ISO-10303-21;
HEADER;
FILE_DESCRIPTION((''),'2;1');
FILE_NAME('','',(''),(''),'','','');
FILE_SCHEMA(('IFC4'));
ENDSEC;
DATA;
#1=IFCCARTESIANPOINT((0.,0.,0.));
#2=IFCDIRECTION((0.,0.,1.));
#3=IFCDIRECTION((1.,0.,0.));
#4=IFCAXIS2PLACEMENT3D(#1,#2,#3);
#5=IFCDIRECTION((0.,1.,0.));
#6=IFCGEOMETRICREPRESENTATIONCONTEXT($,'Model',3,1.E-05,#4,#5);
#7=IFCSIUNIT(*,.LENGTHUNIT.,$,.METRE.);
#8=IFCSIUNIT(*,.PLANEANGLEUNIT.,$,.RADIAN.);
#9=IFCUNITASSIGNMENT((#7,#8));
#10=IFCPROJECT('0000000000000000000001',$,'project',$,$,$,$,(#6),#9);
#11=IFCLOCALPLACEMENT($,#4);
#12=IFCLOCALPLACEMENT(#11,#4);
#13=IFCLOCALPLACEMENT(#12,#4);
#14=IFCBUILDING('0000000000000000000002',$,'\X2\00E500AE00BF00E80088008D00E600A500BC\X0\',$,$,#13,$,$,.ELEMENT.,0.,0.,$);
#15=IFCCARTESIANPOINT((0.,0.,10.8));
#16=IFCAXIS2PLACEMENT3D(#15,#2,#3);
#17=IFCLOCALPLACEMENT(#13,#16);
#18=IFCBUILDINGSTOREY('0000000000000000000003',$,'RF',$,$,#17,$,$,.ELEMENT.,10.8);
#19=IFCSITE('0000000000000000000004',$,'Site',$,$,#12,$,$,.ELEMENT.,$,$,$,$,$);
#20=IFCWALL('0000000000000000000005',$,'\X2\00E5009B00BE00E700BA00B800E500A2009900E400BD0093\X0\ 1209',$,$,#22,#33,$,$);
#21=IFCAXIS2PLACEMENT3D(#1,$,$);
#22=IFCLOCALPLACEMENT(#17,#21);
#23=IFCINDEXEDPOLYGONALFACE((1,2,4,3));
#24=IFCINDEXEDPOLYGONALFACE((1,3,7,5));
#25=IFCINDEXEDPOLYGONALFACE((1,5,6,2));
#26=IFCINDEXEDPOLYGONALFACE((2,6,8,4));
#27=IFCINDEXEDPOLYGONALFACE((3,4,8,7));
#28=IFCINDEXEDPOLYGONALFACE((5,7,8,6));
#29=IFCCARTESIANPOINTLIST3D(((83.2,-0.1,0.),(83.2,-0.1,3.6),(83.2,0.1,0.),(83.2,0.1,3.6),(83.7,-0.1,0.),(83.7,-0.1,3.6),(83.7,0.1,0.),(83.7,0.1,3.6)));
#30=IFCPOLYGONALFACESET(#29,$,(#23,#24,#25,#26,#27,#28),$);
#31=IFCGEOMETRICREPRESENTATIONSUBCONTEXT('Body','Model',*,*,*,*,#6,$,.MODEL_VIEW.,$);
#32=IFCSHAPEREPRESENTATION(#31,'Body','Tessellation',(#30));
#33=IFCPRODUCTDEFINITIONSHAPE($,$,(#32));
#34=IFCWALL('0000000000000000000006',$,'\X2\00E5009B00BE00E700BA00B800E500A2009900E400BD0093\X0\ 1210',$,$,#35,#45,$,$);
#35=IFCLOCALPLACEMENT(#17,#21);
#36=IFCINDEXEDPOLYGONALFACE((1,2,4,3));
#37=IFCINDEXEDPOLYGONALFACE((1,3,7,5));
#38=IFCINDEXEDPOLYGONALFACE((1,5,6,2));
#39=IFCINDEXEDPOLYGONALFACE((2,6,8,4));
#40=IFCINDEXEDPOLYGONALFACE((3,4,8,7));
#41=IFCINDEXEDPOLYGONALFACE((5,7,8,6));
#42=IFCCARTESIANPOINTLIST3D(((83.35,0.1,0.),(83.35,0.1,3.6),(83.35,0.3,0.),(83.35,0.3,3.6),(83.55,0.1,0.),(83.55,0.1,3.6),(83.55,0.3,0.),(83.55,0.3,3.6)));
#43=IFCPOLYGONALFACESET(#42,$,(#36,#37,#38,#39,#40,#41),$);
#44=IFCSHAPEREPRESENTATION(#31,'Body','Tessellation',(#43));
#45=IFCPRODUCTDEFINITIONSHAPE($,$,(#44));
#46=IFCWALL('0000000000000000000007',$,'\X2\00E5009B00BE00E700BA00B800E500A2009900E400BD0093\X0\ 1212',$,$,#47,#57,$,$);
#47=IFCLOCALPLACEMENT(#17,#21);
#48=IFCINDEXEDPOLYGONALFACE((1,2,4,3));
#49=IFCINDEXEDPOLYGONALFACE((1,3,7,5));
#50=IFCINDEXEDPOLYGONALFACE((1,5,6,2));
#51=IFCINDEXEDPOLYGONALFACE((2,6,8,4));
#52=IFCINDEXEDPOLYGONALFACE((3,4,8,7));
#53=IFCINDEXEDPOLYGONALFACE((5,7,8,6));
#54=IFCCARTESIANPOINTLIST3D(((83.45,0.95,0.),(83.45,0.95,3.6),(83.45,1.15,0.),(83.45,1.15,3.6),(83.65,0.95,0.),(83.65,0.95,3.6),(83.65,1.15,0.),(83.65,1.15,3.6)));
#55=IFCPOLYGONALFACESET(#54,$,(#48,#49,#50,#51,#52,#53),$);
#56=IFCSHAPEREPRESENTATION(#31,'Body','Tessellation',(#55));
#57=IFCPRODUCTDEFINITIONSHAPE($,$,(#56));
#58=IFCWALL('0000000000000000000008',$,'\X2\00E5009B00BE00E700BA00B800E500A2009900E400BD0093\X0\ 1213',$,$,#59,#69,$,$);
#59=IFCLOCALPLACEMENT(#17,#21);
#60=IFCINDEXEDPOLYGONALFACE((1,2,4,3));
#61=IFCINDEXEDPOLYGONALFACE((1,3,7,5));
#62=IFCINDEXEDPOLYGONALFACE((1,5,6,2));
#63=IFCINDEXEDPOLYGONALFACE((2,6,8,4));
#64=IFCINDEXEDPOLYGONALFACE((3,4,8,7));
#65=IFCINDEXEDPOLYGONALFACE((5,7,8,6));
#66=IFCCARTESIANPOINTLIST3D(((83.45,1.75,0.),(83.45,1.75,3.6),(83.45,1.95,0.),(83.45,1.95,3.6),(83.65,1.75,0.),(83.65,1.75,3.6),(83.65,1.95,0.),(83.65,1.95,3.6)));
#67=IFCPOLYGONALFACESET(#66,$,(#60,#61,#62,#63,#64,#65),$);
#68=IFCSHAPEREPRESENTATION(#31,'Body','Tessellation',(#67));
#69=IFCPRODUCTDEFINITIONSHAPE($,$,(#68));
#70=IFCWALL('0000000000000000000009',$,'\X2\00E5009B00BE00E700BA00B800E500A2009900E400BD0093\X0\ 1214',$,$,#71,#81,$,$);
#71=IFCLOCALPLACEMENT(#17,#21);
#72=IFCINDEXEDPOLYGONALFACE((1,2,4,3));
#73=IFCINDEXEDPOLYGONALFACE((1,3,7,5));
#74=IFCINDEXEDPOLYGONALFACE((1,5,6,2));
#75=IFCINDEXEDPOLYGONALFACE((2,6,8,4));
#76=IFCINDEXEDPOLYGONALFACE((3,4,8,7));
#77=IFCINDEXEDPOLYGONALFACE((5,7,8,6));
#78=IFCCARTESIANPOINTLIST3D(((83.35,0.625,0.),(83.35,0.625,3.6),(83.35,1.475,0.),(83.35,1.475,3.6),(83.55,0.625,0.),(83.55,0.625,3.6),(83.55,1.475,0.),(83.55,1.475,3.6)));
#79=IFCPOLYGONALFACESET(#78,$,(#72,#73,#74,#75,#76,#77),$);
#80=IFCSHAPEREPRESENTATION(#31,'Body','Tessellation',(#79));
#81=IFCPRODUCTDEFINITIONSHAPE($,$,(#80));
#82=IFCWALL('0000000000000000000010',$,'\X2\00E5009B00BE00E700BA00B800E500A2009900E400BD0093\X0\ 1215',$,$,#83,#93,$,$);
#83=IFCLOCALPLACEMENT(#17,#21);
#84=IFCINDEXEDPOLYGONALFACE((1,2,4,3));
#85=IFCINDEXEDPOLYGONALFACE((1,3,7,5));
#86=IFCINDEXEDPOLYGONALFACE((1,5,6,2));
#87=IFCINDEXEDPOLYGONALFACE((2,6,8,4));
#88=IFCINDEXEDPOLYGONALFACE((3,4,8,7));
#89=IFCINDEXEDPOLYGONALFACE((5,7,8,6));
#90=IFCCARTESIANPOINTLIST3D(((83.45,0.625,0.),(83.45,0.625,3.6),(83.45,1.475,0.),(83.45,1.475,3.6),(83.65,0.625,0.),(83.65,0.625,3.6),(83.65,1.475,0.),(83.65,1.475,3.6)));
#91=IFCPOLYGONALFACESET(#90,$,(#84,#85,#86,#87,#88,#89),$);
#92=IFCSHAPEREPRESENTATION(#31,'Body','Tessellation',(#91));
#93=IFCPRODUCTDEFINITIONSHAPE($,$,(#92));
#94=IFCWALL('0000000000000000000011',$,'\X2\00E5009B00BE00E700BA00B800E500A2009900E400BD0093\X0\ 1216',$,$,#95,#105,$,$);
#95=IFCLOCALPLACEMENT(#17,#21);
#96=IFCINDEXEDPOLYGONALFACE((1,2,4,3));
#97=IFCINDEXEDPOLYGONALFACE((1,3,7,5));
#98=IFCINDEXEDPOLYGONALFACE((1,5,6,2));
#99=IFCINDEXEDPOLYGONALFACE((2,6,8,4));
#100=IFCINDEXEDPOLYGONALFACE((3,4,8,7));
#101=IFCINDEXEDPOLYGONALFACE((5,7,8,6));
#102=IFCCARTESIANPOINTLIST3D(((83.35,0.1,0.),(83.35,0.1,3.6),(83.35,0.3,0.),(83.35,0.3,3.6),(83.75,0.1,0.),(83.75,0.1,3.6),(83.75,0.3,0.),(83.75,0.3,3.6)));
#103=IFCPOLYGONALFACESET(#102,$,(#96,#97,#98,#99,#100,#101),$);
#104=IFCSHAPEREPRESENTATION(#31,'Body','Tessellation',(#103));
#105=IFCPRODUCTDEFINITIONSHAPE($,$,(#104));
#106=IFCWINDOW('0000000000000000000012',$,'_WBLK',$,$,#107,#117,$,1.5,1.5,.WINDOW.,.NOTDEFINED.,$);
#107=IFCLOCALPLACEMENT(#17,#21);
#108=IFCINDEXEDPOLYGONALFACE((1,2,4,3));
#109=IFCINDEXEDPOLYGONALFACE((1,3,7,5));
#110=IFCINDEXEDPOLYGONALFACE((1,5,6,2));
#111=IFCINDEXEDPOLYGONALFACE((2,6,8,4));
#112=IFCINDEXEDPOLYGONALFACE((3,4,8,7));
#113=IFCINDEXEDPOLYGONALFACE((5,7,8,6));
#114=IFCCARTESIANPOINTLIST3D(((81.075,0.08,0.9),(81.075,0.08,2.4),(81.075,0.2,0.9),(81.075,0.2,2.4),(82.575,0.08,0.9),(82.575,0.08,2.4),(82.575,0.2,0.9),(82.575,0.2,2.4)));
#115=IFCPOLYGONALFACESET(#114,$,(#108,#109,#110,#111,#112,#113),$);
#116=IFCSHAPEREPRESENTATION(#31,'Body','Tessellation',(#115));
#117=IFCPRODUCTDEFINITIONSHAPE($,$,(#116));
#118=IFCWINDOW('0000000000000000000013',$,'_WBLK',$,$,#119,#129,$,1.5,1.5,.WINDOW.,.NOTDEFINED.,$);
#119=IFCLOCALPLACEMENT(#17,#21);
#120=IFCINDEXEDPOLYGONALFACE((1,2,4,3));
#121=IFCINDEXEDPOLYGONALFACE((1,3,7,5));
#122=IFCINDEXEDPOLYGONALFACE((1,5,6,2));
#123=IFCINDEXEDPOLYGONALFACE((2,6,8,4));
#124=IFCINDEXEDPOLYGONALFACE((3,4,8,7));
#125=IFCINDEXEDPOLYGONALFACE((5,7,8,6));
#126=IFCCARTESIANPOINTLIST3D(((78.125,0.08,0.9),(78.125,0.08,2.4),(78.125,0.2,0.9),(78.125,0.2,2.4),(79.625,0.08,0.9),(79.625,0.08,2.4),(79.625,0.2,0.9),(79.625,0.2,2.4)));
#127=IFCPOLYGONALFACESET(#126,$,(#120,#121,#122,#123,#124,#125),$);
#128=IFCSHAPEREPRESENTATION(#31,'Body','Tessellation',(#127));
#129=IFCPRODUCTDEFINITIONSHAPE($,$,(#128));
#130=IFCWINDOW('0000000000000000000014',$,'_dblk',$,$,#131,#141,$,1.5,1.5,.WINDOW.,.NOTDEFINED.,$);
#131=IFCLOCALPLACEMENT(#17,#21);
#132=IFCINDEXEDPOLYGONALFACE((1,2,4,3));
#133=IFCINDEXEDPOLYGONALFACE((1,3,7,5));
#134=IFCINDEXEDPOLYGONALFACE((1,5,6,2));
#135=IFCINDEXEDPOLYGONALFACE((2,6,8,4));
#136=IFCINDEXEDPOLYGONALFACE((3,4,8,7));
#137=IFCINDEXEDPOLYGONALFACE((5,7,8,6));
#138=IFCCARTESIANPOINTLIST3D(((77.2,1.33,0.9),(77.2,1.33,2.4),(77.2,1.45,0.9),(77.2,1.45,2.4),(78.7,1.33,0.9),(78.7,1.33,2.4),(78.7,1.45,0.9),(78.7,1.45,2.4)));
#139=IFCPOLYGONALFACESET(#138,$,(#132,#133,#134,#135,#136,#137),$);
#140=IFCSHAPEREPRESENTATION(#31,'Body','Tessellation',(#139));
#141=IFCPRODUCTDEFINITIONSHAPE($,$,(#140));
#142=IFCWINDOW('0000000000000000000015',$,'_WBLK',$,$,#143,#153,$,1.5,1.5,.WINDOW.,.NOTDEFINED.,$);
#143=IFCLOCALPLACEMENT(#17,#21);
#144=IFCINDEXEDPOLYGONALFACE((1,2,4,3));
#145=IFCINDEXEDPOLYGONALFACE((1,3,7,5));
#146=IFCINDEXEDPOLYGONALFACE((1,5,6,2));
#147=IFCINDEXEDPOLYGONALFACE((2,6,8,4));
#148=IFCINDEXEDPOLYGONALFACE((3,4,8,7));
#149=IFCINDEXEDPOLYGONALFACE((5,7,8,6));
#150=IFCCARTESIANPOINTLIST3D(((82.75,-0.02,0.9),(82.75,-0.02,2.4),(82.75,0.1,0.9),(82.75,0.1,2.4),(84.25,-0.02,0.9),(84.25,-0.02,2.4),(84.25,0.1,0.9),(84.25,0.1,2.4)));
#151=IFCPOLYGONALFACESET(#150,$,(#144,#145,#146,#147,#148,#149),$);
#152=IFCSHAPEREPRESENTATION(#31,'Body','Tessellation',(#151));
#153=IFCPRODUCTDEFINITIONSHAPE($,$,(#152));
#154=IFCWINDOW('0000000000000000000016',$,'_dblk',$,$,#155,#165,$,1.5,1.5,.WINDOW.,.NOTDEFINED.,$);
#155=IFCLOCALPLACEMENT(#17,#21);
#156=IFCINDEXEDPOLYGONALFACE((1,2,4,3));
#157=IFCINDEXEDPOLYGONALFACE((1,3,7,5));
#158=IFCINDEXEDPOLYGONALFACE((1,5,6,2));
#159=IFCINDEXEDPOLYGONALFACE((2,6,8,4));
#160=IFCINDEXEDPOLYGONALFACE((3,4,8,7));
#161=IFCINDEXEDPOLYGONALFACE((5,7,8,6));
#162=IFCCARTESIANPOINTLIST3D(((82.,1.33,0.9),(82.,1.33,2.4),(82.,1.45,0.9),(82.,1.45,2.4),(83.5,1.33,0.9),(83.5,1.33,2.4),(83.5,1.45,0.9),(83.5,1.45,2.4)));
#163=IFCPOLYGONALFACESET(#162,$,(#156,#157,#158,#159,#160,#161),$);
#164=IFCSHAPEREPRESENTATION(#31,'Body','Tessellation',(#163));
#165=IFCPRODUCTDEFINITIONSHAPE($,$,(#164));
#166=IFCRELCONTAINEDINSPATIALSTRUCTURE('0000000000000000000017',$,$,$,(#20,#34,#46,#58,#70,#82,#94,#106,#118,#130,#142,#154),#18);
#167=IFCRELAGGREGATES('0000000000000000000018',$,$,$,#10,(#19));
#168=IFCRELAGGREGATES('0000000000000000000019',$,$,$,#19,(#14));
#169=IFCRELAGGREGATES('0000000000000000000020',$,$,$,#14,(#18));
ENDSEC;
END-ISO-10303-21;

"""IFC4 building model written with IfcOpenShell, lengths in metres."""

from ifc_helpers import new_model, si_unit, direction, frame, frame_2d, origin_with_axes, place, context, subcontext, project, spatial, rectangle, extrude, element, save


model = new_model("IFC4")

# Units and contexts
model_context = context("Model", 3, precision=1e-05, world=origin_with_axes(), true_north=direction((0.0, 1.0, 0.0)))
body_context = subcontext(model_context, "Body", "Model", "MODEL_VIEW")
ifc_project = project(units=[si_unit("LENGTHUNIT", "METRE"), si_unit("PLANEANGLEUNIT", "RADIAN")], contexts=[model_context])

# Site, building, storey
placement = place(None, origin_with_axes())
site_placement = place(placement, origin_with_axes())
site = spatial("IfcSite", under=ifc_project, at=site_placement, Name="Site", CompositionType="ELEMENT")
building_placement = place(site_placement, origin_with_axes())
building = spatial("IfcBuilding", under=site, at=building_placement, Name="å®¿è\u0088\u008dæ¥¼", CompositionType="ELEMENT", ElevationOfRefHeight=0.0, ElevationOfTerrain=0.0)
storey_placement = place(building_placement, frame((0.0, 0.0, 10.8), z_axis=(0.0, 0.0, 1.0), x_axis=(1.0, 0.0, 0.0)))
storey = spatial("IfcBuildingStorey", under=building, at=storey_placement, Name="RF", CompositionType="ELEMENT", Elevation=10.8)

# Walls
for number, where, z_axis, x_axis, name in (
    (1, (83.45, 0.0, 0.0), (0.0, 0.0, 1.0), (1.0, 0.0, 0.0), "å\u009b¾çº¸å¢\u0099ä½\u0093 1209"),
):
    element("IfcWall", number, at=place(storey_placement, frame(where, z_axis=z_axis, x_axis=x_axis)), inside=storey, Name=name, context=body_context, shape_type="SweptSolid", body=[
        extrude(rectangle(XDim=0.5, YDim=0.2, at=frame_2d((0.0, 0.0), x_axis=(1.0, 0.0, 0.0))), frame((0.0, 0.0, 0.0), z_axis=(0.0, 0.0, 1.0)), (0.0, 0.0, 1.0), 3.6),
    ])
for number, where, z_axis, x_axis, name in (
    (2, (83.45, 0.2, 0.0), (0.0, 0.0, 1.0), (0.0, -1.0, 0.0), "å\u009b¾çº¸å¢\u0099ä½\u0093 1210"),
    (3, (83.55, 1.05, 0.0), (0.0, 0.0, 1.0), (-1.0, 0.0, 0.0), "å\u009b¾çº¸å¢\u0099ä½\u0093 1212"),
    (4, (83.55, 1.85, 0.0), (0.0, 0.0, 1.0), (-1.0, 0.0, 0.0), "å\u009b¾çº¸å¢\u0099ä½\u0093 1213"),
):
    element("IfcWall", number, at=place(storey_placement, frame(where, z_axis=z_axis, x_axis=x_axis)), inside=storey, Name=name, context=body_context, shape_type="SweptSolid", body=[
        extrude(rectangle(XDim=0.2, YDim=0.2, at=frame_2d((0.0, 0.0), x_axis=(1.0, 0.0, 0.0))), frame((0.0, 0.0, 0.0), z_axis=(0.0, 0.0, 1.0)), (0.0, 0.0, 1.0), 3.6),
    ])
for number, where, z_axis, x_axis, name in (
    (5, (83.45, 1.05, 0.0), (0.0, 0.0, 1.0), (0.0, -1.0, 0.0), "å\u009b¾çº¸å¢\u0099ä½\u0093 1214"),
    (6, (83.55, 1.05, 0.0), (0.0, 0.0, 1.0), (0.0, -1.0, 0.0), "å\u009b¾çº¸å¢\u0099ä½\u0093 1215"),
):
    element("IfcWall", number, at=place(storey_placement, frame(where, z_axis=z_axis, x_axis=x_axis)), inside=storey, Name=name, context=body_context, shape_type="SweptSolid", body=[
        extrude(rectangle(XDim=0.85, YDim=0.2, at=frame_2d((0.0, 0.0), x_axis=(1.0, 0.0, 0.0))), frame((0.0, 0.0, 0.0), z_axis=(0.0, 0.0, 1.0)), (0.0, 0.0, 1.0), 3.6),
    ])
wall_1_placement = place(storey_placement, frame((83.55, 0.2, 0.0), z_axis=(0.0, 0.0, 1.0), x_axis=(1.0, 0.0, 0.0)))
element("IfcWall", 7, at=wall_1_placement, inside=storey, Name="å\u009b¾çº¸å¢\u0099ä½\u0093 1216", context=body_context, shape_type="SweptSolid", body=[
    extrude(rectangle(XDim=0.4, YDim=0.2, at=frame_2d((0.0, 0.0), x_axis=(1.0, 0.0, 0.0))), frame((0.0, 0.0, 0.0), z_axis=(0.0, 0.0, 1.0)), (0.0, 0.0, 1.0), 3.6),
])

# Windows
for number, where, z_axis, x_axis, name in (
    (8, (81.825, 0.14, 0.9), (0.0, 0.0, 1.0), (1.0, 0.0, 0.0), "_WBLK"),
    (9, (78.875, 0.14, 0.9), (0.0, 0.0, 1.0), (1.0, 0.0, 0.0), "_WBLK"),
    (10, (77.95, 1.39, 0.9), (0.0, 0.0, 1.0), (1.0, 0.0, 0.0), "_dblk"),
    (11, (83.5, 0.04, 0.9), (0.0, 0.0, 1.0), (1.0, 0.0, 0.0), "_WBLK"),
    (12, (82.75, 1.39, 0.9), (0.0, 0.0, 1.0), (1.0, 0.0, 0.0), "_dblk"),
):
    element("IfcWindow", number, at=place(storey_placement, frame(where, z_axis=z_axis, x_axis=x_axis)), inside=storey, Name=name, OverallHeight=1.5, OverallWidth=1.5, PartitioningType="NOTDEFINED", PredefinedType="WINDOW", context=body_context, shape_type="SweptSolid", body=[
        extrude(rectangle(XDim=1.5, YDim=0.12, at=frame_2d((0.0, 0.0), x_axis=(1.0, 0.0, 0.0))), frame((0.0, 0.0, 0.0), z_axis=(0.0, 0.0, 1.0)), (0.0, 0.0, 1.0), 1.5),
    ])

save(model, "model.ifc")
